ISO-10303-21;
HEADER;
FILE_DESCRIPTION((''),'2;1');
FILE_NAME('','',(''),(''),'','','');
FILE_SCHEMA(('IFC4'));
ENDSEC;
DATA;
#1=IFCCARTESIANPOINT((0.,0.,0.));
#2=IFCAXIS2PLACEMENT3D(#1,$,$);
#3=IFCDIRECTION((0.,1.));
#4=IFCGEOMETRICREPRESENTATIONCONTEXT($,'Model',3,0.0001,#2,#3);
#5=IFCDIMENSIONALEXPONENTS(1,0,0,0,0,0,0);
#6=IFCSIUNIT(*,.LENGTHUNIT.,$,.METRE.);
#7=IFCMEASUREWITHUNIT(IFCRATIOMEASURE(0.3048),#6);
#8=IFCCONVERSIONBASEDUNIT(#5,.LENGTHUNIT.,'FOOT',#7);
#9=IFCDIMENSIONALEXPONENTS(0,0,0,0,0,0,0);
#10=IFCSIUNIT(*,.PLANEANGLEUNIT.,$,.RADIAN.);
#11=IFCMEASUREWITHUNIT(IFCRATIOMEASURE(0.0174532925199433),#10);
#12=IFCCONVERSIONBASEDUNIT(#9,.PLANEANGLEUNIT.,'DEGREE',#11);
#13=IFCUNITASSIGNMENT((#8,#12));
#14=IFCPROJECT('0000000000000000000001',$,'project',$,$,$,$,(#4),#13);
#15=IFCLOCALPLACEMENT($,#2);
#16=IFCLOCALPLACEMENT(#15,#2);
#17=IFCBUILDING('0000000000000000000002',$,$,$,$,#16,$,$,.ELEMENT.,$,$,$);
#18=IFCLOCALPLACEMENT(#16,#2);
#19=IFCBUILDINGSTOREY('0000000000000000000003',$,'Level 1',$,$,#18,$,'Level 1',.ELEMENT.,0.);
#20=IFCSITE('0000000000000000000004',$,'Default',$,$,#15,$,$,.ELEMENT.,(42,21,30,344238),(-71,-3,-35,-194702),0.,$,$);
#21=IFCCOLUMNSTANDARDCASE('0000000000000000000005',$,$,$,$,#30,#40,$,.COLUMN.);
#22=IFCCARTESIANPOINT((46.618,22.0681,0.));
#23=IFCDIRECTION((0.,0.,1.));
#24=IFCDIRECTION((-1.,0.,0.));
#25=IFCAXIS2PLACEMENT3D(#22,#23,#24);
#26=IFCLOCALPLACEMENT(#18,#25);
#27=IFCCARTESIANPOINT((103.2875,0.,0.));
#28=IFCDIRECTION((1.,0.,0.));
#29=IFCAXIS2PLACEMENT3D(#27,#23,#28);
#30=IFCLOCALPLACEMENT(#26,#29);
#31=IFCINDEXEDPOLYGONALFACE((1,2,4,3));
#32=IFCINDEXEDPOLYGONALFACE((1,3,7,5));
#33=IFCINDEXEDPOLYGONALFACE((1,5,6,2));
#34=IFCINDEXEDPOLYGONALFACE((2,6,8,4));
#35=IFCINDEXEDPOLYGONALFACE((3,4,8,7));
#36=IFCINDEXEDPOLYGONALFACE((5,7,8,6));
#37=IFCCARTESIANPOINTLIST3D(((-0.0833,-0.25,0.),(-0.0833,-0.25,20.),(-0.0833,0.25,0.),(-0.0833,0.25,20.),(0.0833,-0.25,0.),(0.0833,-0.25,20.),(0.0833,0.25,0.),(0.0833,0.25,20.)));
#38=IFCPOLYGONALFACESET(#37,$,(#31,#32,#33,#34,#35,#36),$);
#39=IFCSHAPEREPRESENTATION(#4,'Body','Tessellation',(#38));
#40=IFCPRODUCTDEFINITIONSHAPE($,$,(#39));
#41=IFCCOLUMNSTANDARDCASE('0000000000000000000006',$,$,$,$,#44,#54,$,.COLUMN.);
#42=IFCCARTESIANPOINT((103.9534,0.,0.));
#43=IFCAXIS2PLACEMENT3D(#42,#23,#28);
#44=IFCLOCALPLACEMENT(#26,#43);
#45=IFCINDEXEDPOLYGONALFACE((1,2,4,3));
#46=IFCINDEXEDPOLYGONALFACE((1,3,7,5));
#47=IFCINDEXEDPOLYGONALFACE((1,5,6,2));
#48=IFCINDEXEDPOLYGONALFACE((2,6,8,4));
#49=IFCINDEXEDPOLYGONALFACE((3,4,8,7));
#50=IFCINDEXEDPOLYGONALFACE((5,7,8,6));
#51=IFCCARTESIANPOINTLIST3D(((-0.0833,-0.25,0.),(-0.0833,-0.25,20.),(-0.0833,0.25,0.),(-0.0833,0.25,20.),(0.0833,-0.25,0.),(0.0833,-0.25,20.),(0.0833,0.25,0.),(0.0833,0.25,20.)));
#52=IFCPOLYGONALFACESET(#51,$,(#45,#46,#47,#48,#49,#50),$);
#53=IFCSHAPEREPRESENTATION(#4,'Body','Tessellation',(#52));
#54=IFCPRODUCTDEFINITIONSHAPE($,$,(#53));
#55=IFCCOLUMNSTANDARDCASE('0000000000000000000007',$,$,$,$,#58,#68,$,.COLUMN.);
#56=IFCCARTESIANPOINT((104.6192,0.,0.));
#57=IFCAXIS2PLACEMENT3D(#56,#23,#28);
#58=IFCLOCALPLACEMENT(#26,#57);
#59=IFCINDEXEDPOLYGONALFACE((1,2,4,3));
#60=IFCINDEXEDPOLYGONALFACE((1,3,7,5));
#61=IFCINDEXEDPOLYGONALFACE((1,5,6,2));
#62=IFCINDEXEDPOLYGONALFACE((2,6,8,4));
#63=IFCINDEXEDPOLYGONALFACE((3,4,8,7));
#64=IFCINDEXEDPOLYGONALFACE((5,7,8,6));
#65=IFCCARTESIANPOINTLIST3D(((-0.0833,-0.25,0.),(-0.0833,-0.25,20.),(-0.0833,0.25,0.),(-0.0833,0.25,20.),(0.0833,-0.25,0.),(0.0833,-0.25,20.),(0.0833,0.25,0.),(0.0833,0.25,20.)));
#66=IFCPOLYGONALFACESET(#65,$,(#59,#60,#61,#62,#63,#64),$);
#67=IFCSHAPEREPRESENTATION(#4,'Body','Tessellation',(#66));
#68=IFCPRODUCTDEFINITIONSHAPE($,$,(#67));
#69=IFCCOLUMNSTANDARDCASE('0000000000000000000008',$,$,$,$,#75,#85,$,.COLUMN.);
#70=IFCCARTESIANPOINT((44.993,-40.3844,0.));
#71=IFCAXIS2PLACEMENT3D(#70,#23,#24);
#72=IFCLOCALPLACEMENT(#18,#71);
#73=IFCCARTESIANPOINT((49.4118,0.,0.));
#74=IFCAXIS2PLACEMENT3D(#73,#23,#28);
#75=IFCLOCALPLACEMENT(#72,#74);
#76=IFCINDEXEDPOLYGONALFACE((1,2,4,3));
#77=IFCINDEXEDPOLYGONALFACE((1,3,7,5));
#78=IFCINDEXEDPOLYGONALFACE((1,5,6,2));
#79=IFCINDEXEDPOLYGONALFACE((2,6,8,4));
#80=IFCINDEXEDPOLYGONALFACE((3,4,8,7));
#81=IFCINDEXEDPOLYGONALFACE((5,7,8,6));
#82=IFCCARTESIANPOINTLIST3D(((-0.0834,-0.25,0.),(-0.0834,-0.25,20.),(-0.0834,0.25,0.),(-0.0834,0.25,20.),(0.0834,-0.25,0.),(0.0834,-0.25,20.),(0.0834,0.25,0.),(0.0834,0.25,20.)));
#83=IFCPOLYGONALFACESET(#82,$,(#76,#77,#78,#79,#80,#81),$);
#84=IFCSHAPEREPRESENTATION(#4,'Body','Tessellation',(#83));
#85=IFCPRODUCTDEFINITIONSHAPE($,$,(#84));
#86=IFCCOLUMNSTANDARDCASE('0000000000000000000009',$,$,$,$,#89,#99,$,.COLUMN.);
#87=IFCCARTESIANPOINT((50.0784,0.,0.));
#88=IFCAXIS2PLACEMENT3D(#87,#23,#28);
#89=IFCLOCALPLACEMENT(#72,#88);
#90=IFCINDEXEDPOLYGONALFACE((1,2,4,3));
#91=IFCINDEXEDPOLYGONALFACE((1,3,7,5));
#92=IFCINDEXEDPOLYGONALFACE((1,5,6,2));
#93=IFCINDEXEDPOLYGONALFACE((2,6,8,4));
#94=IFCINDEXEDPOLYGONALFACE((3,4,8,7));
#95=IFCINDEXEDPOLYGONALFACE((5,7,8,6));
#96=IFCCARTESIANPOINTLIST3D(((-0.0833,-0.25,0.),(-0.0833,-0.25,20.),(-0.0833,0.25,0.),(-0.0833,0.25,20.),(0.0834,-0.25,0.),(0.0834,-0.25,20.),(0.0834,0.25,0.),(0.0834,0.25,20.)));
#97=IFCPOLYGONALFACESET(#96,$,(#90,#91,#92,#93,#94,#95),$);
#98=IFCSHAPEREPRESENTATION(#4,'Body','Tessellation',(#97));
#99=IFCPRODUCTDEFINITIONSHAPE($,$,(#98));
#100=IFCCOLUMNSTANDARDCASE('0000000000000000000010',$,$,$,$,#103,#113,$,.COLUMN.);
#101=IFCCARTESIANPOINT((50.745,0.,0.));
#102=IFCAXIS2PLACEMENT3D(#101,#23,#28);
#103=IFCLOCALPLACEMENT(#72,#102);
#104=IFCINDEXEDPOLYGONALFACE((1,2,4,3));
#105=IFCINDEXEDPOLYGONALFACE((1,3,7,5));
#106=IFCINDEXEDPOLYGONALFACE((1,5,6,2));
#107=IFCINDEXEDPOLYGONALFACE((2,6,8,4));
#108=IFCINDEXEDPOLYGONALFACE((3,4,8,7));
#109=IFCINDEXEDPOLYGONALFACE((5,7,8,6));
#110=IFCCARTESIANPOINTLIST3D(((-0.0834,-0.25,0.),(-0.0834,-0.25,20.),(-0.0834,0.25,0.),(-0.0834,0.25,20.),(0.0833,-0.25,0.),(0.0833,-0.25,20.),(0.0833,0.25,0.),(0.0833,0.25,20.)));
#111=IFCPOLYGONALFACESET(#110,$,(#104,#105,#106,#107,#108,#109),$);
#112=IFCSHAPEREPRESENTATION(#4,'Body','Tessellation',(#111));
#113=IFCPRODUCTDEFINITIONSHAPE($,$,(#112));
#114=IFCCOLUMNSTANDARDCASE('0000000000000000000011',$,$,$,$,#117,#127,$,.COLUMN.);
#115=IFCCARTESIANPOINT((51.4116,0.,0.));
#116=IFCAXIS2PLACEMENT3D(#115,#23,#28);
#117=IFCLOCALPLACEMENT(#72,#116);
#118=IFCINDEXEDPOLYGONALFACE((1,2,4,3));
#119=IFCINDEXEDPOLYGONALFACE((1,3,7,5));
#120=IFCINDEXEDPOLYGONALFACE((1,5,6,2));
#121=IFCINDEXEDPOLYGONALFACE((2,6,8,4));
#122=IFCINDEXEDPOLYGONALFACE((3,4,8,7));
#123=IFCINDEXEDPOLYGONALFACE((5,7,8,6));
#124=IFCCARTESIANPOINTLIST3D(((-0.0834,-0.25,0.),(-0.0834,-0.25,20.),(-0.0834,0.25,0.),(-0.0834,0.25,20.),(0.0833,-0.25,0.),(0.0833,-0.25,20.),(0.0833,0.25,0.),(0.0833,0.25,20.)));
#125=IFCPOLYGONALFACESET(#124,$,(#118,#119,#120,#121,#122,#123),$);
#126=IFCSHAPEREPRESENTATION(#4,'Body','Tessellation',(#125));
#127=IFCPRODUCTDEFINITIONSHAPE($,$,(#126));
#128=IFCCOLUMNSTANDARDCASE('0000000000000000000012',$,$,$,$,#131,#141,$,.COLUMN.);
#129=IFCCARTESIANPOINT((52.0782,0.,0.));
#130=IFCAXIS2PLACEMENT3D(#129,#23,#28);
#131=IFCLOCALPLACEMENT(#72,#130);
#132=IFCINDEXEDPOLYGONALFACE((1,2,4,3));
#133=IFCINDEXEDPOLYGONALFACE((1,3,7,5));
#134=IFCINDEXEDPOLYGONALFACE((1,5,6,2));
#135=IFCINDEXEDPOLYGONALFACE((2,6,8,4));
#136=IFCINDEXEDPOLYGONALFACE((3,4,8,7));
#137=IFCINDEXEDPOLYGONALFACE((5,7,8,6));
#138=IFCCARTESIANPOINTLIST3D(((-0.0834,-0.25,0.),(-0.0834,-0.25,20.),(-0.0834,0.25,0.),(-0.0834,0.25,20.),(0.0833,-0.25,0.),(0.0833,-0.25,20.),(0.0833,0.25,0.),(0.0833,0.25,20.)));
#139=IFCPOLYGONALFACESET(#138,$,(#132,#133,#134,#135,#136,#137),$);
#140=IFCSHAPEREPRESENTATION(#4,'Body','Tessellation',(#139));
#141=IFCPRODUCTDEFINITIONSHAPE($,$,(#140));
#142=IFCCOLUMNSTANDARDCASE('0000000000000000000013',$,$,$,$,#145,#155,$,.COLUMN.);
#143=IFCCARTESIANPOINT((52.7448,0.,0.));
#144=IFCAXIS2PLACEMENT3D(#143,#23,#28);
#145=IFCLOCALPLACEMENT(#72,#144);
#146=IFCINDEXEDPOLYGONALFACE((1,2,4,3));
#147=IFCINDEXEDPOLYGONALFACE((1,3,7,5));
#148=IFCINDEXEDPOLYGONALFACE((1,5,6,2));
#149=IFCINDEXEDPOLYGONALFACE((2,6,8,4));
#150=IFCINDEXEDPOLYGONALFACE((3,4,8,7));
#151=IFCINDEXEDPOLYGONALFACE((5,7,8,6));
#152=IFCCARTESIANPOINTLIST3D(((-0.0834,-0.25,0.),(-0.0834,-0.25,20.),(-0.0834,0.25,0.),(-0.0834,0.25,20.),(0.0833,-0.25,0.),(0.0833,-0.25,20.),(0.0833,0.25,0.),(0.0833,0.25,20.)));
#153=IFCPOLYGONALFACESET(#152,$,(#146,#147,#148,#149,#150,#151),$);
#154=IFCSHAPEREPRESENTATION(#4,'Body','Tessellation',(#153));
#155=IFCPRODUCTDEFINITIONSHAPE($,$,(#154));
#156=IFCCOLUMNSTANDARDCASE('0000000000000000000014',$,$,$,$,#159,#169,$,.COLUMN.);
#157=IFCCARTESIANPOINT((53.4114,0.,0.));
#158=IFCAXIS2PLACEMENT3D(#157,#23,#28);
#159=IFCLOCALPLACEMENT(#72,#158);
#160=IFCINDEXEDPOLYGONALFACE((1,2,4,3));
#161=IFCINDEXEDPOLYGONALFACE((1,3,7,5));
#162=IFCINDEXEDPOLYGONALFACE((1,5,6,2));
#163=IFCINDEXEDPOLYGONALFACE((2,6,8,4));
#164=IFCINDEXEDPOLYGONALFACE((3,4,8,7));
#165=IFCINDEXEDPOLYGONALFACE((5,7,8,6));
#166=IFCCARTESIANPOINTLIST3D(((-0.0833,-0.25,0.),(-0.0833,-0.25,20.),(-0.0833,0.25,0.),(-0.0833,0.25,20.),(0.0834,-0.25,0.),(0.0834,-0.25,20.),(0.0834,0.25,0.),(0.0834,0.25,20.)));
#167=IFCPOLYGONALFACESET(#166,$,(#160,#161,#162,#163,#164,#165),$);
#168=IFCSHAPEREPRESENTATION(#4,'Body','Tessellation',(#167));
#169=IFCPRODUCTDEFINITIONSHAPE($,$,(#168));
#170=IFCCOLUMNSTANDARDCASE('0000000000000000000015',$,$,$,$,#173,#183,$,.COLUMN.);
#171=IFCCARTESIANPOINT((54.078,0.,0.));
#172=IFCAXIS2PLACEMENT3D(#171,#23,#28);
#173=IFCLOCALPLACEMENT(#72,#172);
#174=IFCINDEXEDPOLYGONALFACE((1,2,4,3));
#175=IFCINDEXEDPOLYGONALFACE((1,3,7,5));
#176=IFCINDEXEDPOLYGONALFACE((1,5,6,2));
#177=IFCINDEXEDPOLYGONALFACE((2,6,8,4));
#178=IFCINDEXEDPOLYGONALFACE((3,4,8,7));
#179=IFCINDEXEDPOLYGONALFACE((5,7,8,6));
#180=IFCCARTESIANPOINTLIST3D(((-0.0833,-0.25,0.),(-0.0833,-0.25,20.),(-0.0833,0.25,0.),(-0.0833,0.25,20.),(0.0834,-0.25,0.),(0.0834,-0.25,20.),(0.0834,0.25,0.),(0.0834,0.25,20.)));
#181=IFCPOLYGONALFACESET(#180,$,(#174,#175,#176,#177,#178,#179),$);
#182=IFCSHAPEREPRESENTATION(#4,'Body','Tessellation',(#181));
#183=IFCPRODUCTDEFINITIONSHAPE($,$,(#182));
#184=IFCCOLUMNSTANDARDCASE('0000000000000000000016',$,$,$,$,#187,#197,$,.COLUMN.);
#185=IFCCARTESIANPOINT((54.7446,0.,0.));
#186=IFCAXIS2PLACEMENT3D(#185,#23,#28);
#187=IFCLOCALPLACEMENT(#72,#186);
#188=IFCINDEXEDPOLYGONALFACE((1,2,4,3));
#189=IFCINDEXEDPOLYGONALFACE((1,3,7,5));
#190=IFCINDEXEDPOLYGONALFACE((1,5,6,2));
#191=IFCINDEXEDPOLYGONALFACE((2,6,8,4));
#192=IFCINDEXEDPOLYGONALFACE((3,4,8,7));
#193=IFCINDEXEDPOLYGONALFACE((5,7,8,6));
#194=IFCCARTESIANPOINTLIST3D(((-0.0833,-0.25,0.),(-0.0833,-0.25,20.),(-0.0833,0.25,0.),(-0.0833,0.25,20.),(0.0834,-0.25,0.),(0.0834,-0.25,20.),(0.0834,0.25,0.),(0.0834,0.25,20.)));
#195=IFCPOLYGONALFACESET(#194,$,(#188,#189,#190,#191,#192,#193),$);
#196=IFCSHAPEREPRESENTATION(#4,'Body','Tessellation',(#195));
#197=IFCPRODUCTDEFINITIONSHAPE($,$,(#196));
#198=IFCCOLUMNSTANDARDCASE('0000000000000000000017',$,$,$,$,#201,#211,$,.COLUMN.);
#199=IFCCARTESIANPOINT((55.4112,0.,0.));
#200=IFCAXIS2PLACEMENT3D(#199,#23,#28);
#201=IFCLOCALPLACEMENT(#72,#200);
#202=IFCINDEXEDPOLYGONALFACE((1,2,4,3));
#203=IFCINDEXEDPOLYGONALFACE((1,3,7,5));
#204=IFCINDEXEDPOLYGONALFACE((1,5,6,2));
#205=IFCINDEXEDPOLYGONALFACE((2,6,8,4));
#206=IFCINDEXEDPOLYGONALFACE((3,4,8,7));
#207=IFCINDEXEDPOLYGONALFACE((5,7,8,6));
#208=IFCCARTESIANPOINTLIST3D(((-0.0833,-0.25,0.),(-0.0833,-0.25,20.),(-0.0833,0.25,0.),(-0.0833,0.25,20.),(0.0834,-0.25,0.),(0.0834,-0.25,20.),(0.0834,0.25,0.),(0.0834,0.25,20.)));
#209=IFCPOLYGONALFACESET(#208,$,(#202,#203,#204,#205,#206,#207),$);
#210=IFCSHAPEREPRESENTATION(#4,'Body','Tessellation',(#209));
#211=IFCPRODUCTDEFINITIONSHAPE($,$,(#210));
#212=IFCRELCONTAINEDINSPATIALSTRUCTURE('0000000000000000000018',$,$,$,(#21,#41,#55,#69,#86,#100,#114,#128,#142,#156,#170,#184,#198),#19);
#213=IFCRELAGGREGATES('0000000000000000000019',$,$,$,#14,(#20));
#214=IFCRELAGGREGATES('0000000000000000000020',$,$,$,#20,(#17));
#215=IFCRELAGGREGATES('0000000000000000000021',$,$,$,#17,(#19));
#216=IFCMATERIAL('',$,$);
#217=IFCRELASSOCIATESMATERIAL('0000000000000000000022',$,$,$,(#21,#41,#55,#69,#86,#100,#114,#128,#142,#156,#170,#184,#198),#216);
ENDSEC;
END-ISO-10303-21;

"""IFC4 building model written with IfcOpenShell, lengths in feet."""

from ifc_helpers import new_model, entity, si_unit, converted_unit, direction, frame, origin, place, context, project, spatial, rectangle, extrude, material, element, save


model = new_model("IFC4")

# Units and contexts
model_context = context("Model", 3, precision=0.0001, world=origin(), true_north=direction((0.0, 1.0)))
ifc_project = project(units=[converted_unit("LENGTHUNIT", "FOOT", entity("IfcRatioMeasure", 0.3048), si_unit("LENGTHUNIT", "METRE"), dimensions=[1, 0, 0, 0, 0, 0, 0]), converted_unit("PLANEANGLEUNIT", "DEGREE", entity("IfcRatioMeasure", 0.0174532925199433), si_unit("PLANEANGLEUNIT", "RADIAN"), dimensions=[0, 0, 0, 0, 0, 0, 0])], contexts=[model_context])

# Site, building, storey
site_placement = place(None, origin())
site = spatial("IfcSite", under=ifc_project, at=site_placement, Name="Default", CompositionType="ELEMENT", RefLatitude=(42, 21, 30, 344238), RefLongitude=(-71, -3, -35, -194702), RefElevation=0.0)
building_placement = place(site_placement, origin())
building = spatial("IfcBuilding", under=site, at=building_placement, CompositionType="ELEMENT")
storey_placement = place(building_placement, origin())
storey = spatial("IfcBuildingStorey", under=building, at=storey_placement, Name="Level 1", LongName="Level 1", CompositionType="ELEMENT", Elevation=0.0)

# Columns
ifc_material_1 = material(Name="")
placement_1 = place(storey_placement, frame((46.618, 22.0681, 0.0), z_axis=(0.0, 0.0, 1.0), x_axis=(-1.0, 0.0, 0.0)))
for number, where, z_axis, x_axis in (
    (1, (103.2875, 0.0, 0.0), (0.0, 0.0, 1.0), (1.0, 0.0, 0.0)),
    (2, (103.9534, 0.0, 0.0), (0.0, 0.0, 1.0), (1.0, 0.0, 0.0)),
    (3, (104.6192, 0.0, 0.0), (0.0, 0.0, 1.0), (1.0, 0.0, 0.0)),
):
    element("IfcColumnStandardCase", number, at=place(placement_1, frame(where, z_axis=z_axis, x_axis=x_axis)), inside=storey, material=ifc_material_1, PredefinedType="COLUMN", context=model_context, shape_type="SweptSolid", body=[
        extrude(rectangle(XDim=0.1667, YDim=0.5), origin(), (0.0, 0.0, 1.0), 20.0),
    ])
placement_2 = place(storey_placement, frame((44.993, -40.3844, 0.0), z_axis=(0.0, 0.0, 1.0), x_axis=(-1.0, 0.0, 0.0)))
for number, where, z_axis, x_axis in (
    (4, (49.4118, 0.0, 0.0), (0.0, 0.0, 1.0), (1.0, 0.0, 0.0)),
    (5, (50.0784, 0.0, 0.0), (0.0, 0.0, 1.0), (1.0, 0.0, 0.0)),
    (6, (50.745, 0.0, 0.0), (0.0, 0.0, 1.0), (1.0, 0.0, 0.0)),
    (7, (51.4116, 0.0, 0.0), (0.0, 0.0, 1.0), (1.0, 0.0, 0.0)),
    (8, (52.0782, 0.0, 0.0), (0.0, 0.0, 1.0), (1.0, 0.0, 0.0)),
    (9, (52.7448, 0.0, 0.0), (0.0, 0.0, 1.0), (1.0, 0.0, 0.0)),
    (10, (53.4114, 0.0, 0.0), (0.0, 0.0, 1.0), (1.0, 0.0, 0.0)),
    (11, (54.078, 0.0, 0.0), (0.0, 0.0, 1.0), (1.0, 0.0, 0.0)),
    (12, (54.7446, 0.0, 0.0), (0.0, 0.0, 1.0), (1.0, 0.0, 0.0)),
    (13, (55.4112, 0.0, 0.0), (0.0, 0.0, 1.0), (1.0, 0.0, 0.0)),
):
    element("IfcColumnStandardCase", number, at=place(placement_2, frame(where, z_axis=z_axis, x_axis=x_axis)), inside=storey, material=ifc_material_1, PredefinedType="COLUMN", context=model_context, shape_type="SweptSolid", body=[
        extrude(rectangle(XDim=0.1667, YDim=0.5), origin(), (0.0, 0.0, 1.0), 20.0),
    ])

save(model, "model.ifc")
